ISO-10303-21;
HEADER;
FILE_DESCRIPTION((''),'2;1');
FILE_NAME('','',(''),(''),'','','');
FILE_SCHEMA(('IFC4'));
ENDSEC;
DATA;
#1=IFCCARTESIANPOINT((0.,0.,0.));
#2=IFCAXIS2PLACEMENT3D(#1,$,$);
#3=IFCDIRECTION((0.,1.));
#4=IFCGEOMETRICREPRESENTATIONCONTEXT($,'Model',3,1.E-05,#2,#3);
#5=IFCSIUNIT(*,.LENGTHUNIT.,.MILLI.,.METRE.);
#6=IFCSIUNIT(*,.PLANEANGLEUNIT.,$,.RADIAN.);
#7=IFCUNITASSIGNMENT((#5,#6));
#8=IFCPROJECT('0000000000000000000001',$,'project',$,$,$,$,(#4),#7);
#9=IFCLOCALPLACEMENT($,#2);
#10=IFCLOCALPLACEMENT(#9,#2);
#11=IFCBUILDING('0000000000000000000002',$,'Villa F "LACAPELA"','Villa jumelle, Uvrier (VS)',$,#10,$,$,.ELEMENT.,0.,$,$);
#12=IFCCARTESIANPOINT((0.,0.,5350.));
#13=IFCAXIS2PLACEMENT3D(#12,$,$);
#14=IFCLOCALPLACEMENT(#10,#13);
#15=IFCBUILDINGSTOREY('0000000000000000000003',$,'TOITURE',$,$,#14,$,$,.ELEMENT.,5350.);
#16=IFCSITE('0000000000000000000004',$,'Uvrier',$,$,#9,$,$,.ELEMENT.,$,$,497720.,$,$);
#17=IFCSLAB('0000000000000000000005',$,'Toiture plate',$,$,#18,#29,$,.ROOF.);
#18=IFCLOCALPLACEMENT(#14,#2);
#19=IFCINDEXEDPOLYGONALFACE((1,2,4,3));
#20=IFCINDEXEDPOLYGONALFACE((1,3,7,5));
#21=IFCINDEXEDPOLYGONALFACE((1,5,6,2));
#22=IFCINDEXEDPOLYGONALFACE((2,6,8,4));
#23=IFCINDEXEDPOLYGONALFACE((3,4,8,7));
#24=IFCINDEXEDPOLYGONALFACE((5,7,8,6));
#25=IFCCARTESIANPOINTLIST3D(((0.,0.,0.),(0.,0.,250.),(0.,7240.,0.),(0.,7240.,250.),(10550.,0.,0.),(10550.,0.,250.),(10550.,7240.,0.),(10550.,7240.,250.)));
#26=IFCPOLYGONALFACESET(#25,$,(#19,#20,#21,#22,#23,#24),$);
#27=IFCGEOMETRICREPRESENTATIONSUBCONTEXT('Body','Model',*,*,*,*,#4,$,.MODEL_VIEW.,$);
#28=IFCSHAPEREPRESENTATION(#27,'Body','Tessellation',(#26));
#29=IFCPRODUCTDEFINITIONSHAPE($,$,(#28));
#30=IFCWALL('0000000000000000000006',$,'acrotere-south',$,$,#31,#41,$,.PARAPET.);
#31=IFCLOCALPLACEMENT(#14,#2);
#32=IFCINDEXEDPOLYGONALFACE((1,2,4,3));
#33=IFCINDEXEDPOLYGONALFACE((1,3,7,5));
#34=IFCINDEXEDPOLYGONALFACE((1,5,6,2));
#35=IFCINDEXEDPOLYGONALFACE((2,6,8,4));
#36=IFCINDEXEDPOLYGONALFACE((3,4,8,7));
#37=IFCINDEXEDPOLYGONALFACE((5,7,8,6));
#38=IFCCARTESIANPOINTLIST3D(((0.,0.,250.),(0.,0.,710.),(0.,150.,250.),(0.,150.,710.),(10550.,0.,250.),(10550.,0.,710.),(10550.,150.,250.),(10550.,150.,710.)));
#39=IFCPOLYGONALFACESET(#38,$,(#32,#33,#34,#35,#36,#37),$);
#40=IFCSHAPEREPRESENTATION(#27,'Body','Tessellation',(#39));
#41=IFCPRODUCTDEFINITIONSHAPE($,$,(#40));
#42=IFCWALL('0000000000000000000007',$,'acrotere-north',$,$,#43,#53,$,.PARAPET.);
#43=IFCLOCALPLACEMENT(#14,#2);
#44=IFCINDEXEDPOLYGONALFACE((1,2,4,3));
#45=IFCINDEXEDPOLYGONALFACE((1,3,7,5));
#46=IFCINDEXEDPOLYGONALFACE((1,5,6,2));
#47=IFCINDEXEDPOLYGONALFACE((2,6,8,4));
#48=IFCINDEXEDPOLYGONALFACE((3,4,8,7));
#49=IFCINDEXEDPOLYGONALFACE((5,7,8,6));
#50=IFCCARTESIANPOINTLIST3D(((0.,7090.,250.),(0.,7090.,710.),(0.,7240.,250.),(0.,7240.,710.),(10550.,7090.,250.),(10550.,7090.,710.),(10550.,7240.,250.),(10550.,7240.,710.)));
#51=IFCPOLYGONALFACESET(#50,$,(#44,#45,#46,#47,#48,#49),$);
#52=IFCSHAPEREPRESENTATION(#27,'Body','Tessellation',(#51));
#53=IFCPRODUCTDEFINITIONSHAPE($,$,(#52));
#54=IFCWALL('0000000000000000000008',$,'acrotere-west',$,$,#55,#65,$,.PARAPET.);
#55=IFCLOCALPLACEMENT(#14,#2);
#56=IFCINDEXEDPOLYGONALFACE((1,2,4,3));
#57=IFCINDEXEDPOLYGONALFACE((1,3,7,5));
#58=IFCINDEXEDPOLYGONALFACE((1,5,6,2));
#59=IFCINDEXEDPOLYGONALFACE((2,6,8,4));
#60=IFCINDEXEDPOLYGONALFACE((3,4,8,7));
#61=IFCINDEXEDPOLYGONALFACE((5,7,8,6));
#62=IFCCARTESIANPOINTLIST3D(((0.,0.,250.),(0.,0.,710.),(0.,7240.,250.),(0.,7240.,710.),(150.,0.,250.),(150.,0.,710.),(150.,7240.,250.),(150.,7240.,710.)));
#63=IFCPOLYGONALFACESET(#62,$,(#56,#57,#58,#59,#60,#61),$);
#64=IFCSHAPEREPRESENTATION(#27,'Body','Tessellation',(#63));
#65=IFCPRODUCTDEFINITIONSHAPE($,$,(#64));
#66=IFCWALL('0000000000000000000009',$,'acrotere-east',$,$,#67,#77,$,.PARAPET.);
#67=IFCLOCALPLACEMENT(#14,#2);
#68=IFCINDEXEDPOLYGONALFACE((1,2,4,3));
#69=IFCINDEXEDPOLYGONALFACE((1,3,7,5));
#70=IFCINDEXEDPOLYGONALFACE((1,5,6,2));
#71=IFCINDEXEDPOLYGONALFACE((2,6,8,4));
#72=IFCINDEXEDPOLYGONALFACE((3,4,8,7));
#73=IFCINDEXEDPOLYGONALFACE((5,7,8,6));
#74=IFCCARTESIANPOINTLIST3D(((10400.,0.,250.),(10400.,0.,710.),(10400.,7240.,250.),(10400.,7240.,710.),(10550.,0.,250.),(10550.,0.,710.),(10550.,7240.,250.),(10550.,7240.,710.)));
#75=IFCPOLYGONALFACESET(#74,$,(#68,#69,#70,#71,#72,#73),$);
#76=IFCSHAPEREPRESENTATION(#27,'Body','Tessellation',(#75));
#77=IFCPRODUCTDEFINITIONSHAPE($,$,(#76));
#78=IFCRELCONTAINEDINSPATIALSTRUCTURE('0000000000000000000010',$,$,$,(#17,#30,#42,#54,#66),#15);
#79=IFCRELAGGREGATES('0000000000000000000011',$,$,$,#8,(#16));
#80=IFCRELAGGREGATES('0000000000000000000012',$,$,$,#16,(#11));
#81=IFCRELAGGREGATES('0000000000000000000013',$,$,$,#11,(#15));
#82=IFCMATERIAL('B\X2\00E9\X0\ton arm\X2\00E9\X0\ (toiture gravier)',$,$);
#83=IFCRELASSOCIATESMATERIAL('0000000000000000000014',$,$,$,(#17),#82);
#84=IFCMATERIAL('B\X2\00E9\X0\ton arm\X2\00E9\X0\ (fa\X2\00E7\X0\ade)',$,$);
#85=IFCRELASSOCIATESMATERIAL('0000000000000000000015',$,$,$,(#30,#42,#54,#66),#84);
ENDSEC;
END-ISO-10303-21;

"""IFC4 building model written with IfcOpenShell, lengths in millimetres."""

from ifc_helpers import new_model, si_unit, direction, frame, frame_2d, origin, place, context, subcontext, project, spatial, polyline, rectangle, outline, extrude, material, element, save


model = new_model("IFC4")

# Units and contexts
model_context = context("Model", 3, precision=1e-05, world=origin(), true_north=direction((0.0, 1.0)))
body_context = subcontext(model_context, "Body", "Model", "MODEL_VIEW")
ifc_project = project(units=[si_unit("LENGTHUNIT", "METRE", prefix="MILLI"), si_unit("PLANEANGLEUNIT", "RADIAN")], contexts=[model_context])

# Site, building, storey
site_placement = place(None, origin())
site = spatial("IfcSite", under=ifc_project, at=site_placement, Name="Uvrier", CompositionType="ELEMENT", RefElevation=497720.0)
building_placement = place(site_placement, origin())
building = spatial("IfcBuilding", under=site, at=building_placement, Name="Villa F \"LACAPELA\"", Description="Villa jumelle, Uvrier (VS)", CompositionType="ELEMENT", ElevationOfRefHeight=0.0)
storey_placement = place(building_placement, frame((0.0, 0.0, 5350.0)))
storey = spatial("IfcBuildingStorey", under=building, at=storey_placement, Name="TOITURE", CompositionType="ELEMENT", Elevation=5350.0)

# Slab
ifc_material_1 = material(Name="Béton armé (toiture gravier)")
slab_placement = place(storey_placement, origin())
element("IfcSlab", 1, at=slab_placement, inside=storey, material=ifc_material_1, Name="Toiture plate", PredefinedType="ROOF", context=body_context, shape_type="SweptSolid", body=[
    extrude(outline(polyline([(0.0, 0.0), (10550.0, 0.0), (10550.0, 7240.0), (0.0, 7240.0), (0.0, 0.0)])), origin(), (0.0, 0.0, 1.0), 250.0),
])

# Walls
ifc_material_2 = material(Name="Béton armé (façade)")
wall_1_placement = place(storey_placement, origin())
element("IfcWall", 2, at=wall_1_placement, inside=storey, material=ifc_material_2, Name="acrotere-south", PredefinedType="PARAPET", context=body_context, shape_type="SweptSolid", body=[
    extrude(rectangle(XDim=10550.0, YDim=150.0, at=frame_2d((5275.0, 75.0))), frame((0.0, 0.0, 250.0)), (0.0, 0.0, 1.0), 460.0),
])
wall_2_placement = place(storey_placement, origin())
element("IfcWall", 3, at=wall_2_placement, inside=storey, material=ifc_material_2, Name="acrotere-north", PredefinedType="PARAPET", context=body_context, shape_type="SweptSolid", body=[
    extrude(rectangle(XDim=10550.0, YDim=150.0, at=frame_2d((5275.0, 7165.0))), frame((0.0, 0.0, 250.0)), (0.0, 0.0, 1.0), 460.0),
])
wall_3_placement = place(storey_placement, origin())
element("IfcWall", 4, at=wall_3_placement, inside=storey, material=ifc_material_2, Name="acrotere-west", PredefinedType="PARAPET", context=body_context, shape_type="SweptSolid", body=[
    extrude(rectangle(XDim=150.0, YDim=7240.0, at=frame_2d((75.0, 3620.0))), frame((0.0, 0.0, 250.0)), (0.0, 0.0, 1.0), 460.0),
])
wall_4_placement = place(storey_placement, origin())
element("IfcWall", 5, at=wall_4_placement, inside=storey, material=ifc_material_2, Name="acrotere-east", PredefinedType="PARAPET", context=body_context, shape_type="SweptSolid", body=[
    extrude(rectangle(XDim=150.0, YDim=7240.0, at=frame_2d((10475.0, 3620.0))), frame((0.0, 0.0, 250.0)), (0.0, 0.0, 1.0), 460.0),
])

save(model, "model.ifc")
